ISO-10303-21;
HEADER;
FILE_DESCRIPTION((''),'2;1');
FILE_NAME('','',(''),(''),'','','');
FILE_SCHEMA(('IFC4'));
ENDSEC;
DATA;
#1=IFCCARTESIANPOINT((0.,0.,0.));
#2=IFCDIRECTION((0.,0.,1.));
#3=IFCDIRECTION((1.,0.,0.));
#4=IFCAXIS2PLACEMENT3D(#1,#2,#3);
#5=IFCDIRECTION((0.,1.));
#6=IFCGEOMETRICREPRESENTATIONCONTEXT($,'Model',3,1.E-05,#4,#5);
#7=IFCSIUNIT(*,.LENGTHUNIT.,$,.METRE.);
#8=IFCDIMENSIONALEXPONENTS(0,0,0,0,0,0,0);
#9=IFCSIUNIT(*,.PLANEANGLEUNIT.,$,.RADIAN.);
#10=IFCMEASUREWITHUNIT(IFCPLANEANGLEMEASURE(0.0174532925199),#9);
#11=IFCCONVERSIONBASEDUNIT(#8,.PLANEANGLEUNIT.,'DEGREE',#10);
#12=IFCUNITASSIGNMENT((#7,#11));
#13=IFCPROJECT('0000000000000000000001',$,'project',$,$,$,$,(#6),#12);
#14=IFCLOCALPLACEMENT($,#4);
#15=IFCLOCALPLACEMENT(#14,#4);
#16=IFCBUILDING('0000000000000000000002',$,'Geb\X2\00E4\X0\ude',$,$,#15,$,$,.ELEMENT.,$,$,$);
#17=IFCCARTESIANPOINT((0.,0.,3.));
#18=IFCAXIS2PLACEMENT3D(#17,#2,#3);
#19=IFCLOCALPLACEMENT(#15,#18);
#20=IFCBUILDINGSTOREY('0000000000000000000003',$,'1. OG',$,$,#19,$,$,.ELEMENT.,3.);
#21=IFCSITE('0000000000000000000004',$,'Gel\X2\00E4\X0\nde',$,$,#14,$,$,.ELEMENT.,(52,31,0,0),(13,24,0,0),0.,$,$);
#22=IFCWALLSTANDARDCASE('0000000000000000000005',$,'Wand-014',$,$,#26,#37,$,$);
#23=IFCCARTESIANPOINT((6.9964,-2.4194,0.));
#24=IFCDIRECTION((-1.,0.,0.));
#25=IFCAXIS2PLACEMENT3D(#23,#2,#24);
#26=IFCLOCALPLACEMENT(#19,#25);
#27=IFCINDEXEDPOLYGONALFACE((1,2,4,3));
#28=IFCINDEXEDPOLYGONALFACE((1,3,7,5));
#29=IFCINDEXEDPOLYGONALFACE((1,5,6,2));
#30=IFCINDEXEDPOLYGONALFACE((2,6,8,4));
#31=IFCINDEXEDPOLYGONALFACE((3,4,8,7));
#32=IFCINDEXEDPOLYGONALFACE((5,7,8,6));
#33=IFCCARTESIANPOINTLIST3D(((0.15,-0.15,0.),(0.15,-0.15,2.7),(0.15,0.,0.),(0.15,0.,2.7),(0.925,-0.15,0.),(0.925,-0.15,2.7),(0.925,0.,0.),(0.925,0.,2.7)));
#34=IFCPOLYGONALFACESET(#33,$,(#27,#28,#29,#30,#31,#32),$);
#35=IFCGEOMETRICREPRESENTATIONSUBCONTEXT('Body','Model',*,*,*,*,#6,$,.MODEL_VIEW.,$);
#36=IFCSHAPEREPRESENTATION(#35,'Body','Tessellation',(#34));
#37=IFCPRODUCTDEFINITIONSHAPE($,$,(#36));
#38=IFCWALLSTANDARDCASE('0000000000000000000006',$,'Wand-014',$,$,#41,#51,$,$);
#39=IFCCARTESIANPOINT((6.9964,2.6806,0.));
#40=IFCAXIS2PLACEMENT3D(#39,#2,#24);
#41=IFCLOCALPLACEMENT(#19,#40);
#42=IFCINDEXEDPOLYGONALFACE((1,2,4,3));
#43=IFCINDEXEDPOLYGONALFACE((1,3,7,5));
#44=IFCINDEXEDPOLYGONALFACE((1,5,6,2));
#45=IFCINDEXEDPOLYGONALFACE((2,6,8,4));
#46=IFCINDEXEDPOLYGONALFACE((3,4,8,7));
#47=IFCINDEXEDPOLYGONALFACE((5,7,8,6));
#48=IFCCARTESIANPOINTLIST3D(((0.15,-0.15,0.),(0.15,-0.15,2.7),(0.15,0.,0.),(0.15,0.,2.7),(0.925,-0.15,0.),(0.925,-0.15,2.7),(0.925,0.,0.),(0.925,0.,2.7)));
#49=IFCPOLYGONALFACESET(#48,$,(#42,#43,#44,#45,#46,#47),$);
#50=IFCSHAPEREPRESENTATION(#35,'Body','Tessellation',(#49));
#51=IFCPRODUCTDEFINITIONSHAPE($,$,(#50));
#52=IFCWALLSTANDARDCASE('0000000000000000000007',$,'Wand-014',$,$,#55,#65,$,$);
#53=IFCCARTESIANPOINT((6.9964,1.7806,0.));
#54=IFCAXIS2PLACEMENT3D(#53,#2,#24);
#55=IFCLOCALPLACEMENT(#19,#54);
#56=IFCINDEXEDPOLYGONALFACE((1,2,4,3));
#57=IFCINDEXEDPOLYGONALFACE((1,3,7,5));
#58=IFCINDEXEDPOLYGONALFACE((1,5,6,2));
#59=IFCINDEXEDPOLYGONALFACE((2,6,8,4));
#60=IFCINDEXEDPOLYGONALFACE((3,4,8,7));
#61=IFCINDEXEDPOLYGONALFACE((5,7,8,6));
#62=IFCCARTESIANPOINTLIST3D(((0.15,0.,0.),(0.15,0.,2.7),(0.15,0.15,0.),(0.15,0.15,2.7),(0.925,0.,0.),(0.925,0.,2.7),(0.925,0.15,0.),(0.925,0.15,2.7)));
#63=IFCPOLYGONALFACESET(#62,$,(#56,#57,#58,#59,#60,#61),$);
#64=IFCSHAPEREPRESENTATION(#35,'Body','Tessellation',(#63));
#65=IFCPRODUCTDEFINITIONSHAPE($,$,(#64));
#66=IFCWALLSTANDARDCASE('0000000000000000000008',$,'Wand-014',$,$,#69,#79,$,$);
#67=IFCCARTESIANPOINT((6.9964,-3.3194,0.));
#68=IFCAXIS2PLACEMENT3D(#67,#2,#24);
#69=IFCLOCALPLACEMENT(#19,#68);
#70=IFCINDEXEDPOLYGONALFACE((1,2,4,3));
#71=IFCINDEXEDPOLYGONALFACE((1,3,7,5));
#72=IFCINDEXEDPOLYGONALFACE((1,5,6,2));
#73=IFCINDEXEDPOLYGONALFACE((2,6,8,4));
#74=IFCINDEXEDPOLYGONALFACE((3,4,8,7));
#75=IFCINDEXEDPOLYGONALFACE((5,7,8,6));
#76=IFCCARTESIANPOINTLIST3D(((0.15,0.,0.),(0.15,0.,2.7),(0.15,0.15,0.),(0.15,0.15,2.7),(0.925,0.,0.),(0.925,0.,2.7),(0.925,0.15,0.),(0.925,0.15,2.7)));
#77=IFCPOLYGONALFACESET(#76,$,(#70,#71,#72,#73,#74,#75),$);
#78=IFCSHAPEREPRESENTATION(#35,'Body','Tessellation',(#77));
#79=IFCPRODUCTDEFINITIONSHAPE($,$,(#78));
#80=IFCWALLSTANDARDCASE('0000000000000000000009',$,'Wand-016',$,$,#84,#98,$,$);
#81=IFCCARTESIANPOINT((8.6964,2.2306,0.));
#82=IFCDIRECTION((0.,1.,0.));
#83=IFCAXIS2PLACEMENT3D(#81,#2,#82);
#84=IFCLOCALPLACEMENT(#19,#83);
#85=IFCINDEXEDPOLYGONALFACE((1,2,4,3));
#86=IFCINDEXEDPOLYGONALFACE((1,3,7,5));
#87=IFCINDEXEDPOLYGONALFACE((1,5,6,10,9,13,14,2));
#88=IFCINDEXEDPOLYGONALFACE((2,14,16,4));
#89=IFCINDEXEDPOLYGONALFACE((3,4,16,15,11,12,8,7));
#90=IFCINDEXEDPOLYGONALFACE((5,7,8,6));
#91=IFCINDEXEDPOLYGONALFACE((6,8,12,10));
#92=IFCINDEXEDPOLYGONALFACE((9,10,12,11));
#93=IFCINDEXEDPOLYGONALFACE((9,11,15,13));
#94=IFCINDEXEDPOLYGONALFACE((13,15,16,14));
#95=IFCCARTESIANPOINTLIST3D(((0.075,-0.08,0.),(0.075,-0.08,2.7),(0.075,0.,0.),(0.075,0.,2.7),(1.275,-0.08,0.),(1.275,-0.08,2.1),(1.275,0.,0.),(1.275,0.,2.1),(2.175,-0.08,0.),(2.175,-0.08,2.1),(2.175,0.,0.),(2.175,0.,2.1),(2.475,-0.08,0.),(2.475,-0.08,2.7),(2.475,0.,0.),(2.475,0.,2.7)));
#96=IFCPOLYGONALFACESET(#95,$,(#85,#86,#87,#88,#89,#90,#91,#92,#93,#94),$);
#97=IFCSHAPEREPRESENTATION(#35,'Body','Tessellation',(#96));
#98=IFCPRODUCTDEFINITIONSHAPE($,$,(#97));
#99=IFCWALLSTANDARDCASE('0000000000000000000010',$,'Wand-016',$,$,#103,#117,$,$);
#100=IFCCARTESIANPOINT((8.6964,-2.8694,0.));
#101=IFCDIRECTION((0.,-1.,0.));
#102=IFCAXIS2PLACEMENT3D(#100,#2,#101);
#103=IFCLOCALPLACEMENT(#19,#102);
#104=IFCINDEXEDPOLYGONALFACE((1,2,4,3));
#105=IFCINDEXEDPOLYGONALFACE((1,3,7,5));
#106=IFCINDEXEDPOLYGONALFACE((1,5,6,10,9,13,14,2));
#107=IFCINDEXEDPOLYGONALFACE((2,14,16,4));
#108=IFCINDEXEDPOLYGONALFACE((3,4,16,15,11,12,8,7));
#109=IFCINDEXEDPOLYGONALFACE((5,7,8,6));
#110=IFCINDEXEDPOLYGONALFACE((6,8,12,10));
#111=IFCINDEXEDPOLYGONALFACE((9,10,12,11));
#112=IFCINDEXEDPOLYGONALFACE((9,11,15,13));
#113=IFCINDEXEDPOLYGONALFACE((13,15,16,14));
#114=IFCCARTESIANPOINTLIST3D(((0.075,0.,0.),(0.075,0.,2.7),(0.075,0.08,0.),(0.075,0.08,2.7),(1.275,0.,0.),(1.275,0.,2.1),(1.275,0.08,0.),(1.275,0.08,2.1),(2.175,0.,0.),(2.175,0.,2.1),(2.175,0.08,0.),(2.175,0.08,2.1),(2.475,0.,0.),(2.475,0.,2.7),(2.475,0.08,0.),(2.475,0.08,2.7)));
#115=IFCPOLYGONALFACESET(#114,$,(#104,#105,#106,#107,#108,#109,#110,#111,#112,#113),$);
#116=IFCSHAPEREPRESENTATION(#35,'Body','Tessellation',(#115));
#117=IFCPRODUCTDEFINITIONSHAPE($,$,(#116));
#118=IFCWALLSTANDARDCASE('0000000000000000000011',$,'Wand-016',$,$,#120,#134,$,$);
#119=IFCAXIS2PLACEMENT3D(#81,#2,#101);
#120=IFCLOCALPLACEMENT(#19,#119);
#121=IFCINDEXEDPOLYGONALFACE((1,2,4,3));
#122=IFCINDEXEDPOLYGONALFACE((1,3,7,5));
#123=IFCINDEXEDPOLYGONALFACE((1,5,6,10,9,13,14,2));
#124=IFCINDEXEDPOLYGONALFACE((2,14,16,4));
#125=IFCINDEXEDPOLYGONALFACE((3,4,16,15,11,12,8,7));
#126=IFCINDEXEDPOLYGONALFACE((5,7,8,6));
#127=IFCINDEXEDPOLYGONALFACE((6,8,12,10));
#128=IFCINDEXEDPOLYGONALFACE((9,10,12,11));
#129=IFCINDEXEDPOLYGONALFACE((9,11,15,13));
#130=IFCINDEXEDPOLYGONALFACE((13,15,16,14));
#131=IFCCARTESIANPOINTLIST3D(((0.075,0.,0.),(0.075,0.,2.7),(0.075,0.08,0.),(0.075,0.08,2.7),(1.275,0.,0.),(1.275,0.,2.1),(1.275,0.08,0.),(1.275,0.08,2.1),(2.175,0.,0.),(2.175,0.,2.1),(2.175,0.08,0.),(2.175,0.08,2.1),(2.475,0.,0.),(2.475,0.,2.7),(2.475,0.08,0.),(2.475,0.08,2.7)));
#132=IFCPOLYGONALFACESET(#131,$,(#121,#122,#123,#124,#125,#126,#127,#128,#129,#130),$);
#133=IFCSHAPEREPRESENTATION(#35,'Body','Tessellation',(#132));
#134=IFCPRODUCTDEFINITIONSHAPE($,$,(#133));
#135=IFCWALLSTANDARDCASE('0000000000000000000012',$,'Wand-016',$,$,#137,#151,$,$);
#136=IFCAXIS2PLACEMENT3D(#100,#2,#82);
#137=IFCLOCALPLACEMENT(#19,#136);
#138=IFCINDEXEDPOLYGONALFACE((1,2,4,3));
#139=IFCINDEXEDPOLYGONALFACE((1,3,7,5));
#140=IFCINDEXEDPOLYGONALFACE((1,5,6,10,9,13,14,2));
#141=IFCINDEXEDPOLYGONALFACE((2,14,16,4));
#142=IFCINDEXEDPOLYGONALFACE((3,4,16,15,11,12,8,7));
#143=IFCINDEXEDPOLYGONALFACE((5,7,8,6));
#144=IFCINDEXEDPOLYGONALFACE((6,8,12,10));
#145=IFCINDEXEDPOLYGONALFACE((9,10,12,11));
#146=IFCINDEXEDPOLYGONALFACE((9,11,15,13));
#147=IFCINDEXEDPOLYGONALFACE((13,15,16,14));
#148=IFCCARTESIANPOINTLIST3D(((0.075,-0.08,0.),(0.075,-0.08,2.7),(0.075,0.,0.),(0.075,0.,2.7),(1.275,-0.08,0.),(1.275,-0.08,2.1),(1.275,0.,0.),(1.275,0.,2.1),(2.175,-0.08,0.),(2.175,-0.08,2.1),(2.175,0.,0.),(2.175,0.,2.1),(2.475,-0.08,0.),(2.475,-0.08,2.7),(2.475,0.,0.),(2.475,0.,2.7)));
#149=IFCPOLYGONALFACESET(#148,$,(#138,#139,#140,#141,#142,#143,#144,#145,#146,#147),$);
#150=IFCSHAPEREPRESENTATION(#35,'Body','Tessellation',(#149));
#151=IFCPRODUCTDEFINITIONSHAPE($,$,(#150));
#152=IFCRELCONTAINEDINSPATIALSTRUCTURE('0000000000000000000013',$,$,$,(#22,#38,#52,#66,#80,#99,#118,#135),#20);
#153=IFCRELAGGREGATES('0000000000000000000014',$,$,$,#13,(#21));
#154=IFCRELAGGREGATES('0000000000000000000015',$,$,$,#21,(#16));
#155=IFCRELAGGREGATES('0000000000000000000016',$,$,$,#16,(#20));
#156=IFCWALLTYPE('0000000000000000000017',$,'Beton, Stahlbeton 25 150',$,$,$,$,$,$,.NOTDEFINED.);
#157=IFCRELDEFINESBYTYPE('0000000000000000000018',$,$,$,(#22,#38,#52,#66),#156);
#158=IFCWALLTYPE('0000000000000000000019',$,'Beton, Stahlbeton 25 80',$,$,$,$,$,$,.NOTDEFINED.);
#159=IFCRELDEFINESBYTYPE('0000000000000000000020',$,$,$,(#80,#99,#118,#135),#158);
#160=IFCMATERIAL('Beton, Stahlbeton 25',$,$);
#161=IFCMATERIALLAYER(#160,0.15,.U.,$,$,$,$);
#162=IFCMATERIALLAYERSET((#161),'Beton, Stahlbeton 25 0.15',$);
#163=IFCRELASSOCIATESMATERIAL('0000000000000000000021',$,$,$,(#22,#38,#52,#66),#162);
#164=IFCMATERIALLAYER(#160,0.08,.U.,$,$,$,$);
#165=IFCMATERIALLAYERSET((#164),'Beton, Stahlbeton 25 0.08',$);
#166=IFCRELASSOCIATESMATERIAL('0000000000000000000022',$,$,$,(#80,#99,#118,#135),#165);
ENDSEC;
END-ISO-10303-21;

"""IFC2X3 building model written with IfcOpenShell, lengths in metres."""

from ifc_helpers import new_model, entity, si_unit, converted_unit, direction, frame, origin_with_axes, origin_2d_with_axis, place, context, subcontext, project, spatial, polyline, rectangle, outline, extrude, material, layer, layer_set, layer_usage, type_object, element, save


model = new_model("IFC2X3")

# Units and contexts
model_context = context("Model", 3, precision=1e-05, world=origin_with_axes(), true_north=direction((0.0, 1.0)))
body_context = subcontext(model_context, "Body", "Model", "MODEL_VIEW")
ifc_project = project(units=[si_unit("LENGTHUNIT", "METRE"), converted_unit("PLANEANGLEUNIT", "DEGREE", entity("IfcPlaneAngleMeasure", 0.0174532925199), si_unit("PLANEANGLEUNIT", "RADIAN"), dimensions=[0, 0, 0, 0, 0, 0, 0])], contexts=[model_context])

# Site, building, storey
site_placement = place(None, origin_with_axes())
site = spatial("IfcSite", under=ifc_project, at=site_placement, Name="Gelände", CompositionType="ELEMENT", RefLatitude=(52, 31, 0, 0), RefLongitude=(13, 24, 0, 0), RefElevation=0.0)
building_placement = place(site_placement, origin_with_axes())
building = spatial("IfcBuilding", under=site, at=building_placement, Name="Gebäude", CompositionType="ELEMENT")
storey_placement = place(building_placement, frame((0.0, 0.0, 3.0), z_axis=(0.0, 0.0, 1.0), x_axis=(1.0, 0.0, 0.0)))
storey = spatial("IfcBuildingStorey", under=building, at=storey_placement, Name="1. OG", CompositionType="ELEMENT", Elevation=3.0)

# Wall
ifc_material = material(Name="Beton, Stahlbeton 25")
ifc_layer_1 = layer(ifc_material, 0.15, ventilated="UNKNOWN")
ifc_layer_set_1 = layer_set([ifc_layer_1], Name="Beton, Stahlbeton 25 0.15")
ifc_layer_usage_1 = layer_usage(ifc_layer_set_1, "AXIS2", "NEGATIVE", 0.0)
wall_type_1 = type_object("IfcWallType", Name="Beton, Stahlbeton 25 150", PredefinedType="NOTDEFINED")
wall_1_placement = place(storey_placement, frame((6.9964, -2.4194, 0.0), z_axis=(0.0, 0.0, 1.0), x_axis=(-1.0, 0.0, 0.0)))
element("IfcWallStandardCase", 1, at=wall_1_placement, inside=storey, type_object=wall_type_1, material=ifc_layer_usage_1, Name="Wand-014", context=body_context, shape_type="SweptSolid", body=[
    extrude(outline(polyline([(0.15, -0.15), (0.925, -0.15), (0.925, 0.0), (0.15, 0.0), (0.15, -0.15)])), origin_with_axes(), (0.0, 0.0, 1.0), 2.7),
])

# Walls
ifc_layer_usage_2 = layer_usage(ifc_layer_set_1, "AXIS2", "NEGATIVE", 0.0)
wall_2_placement = place(storey_placement, frame((6.9964, 2.6806, 0.0), z_axis=(0.0, 0.0, 1.0), x_axis=(-1.0, 0.0, 0.0)))
element("IfcWallStandardCase", 2, at=wall_2_placement, inside=storey, type_object=wall_type_1, material=ifc_layer_usage_2, Name="Wand-014", context=body_context, shape_type="SweptSolid", body=[
    extrude(outline(polyline([(0.15, -0.15), (0.925, -0.15), (0.925, 0.0), (0.15, 0.0), (0.15, -0.15)])), origin_with_axes(), (0.0, 0.0, 1.0), 2.7),
])
ifc_layer_usage_3 = layer_usage(ifc_layer_set_1, "AXIS2", "POSITIVE", 0.0)
wall_3_placement = place(storey_placement, frame((6.9964, 1.7806, 0.0), z_axis=(0.0, 0.0, 1.0), x_axis=(-1.0, 0.0, 0.0)))
element("IfcWallStandardCase", 3, at=wall_3_placement, inside=storey, type_object=wall_type_1, material=ifc_layer_usage_3, Name="Wand-014", context=body_context, shape_type="SweptSolid", body=[
    extrude(outline(polyline([(0.15, 0.0), (0.925, 0.0), (0.925, 0.15), (0.15, 0.15), (0.15, 0.0)])), origin_with_axes(), (0.0, 0.0, 1.0), 2.7),
])

# Wall
ifc_layer_usage_4 = layer_usage(ifc_layer_set_1, "AXIS2", "POSITIVE", 0.0)
wall_4_placement = place(storey_placement, frame((6.9964, -3.3194, 0.0), z_axis=(0.0, 0.0, 1.0), x_axis=(-1.0, 0.0, 0.0)))
element("IfcWallStandardCase", 4, at=wall_4_placement, inside=storey, type_object=wall_type_1, material=ifc_layer_usage_4, Name="Wand-014", context=body_context, shape_type="SweptSolid", body=[
    extrude(outline(polyline([(0.15, 0.0), (0.925, 0.0), (0.925, 0.15), (0.15, 0.15), (0.15, 0.0)])), origin_with_axes(), (0.0, 0.0, 1.0), 2.7),
])

# Walls, openings
ifc_layer_2 = layer(ifc_material, 0.08, ventilated="UNKNOWN")
ifc_layer_set_2 = layer_set([ifc_layer_2], Name="Beton, Stahlbeton 25 0.08")
wall_type_2 = type_object("IfcWallType", Name="Beton, Stahlbeton 25 80", PredefinedType="NOTDEFINED")
ifc_layer_usage_5 = layer_usage(ifc_layer_set_2, "AXIS2", "NEGATIVE", 0.0)
wall_5_placement = place(storey_placement, frame((8.6964, 2.2306, 0.0), z_axis=(0.0, 0.0, 1.0), x_axis=(0.0, 1.0, 0.0)))
wall_5 = element("IfcWallStandardCase", 5, at=wall_5_placement, inside=storey, type_object=wall_type_2, material=ifc_layer_usage_5, Name="Wand-016", context=body_context, shape_type="SweptSolid", body=[
    extrude(outline(polyline([(0.075, -0.08), (2.475, -0.08), (2.475, 0.0), (0.075, 0.0), (0.075, -0.08)])), origin_with_axes(), (0.0, 0.0, 1.0), 2.7),
])
opening_1_placement = place(wall_5_placement, frame((1.725, 0.0, 0.0), z_axis=(0.0, 0.0, 1.0), x_axis=(1.0, 0.0, 0.0)))
element("IfcOpeningElement", 6, at=opening_1_placement, cuts=wall_5, context=body_context, shape_type="SweptSolid", body=[
    extrude(rectangle(XDim=0.9, YDim=2.1, at=origin_2d_with_axis()), frame((0.0, -0.16, 1.05), z_axis=(0.0, 1.0, 0.0), x_axis=(1.0, 0.0, 0.0)), (0.0, 0.0, 1.0), 0.08),
    extrude(rectangle(XDim=0.9, YDim=2.1, at=origin_2d_with_axis()), frame((0.0, 0.0, 1.05), z_axis=(0.0, -1.0, 0.0), x_axis=(1.0, 0.0, 0.0)), (0.0, 0.0, 1.0), 0.08),
])
ifc_layer_usage_6 = layer_usage(ifc_layer_set_2, "AXIS2", "POSITIVE", 0.0)
wall_6_placement = place(storey_placement, frame((8.6964, -2.8694, 0.0), z_axis=(0.0, 0.0, 1.0), x_axis=(0.0, -1.0, 0.0)))
wall_6 = element("IfcWallStandardCase", 7, at=wall_6_placement, inside=storey, type_object=wall_type_2, material=ifc_layer_usage_6, Name="Wand-016", context=body_context, shape_type="SweptSolid", body=[
    extrude(outline(polyline([(0.075, 0.0), (2.475, 0.0), (2.475, 0.08), (0.075, 0.08), (0.075, 0.0)])), origin_with_axes(), (0.0, 0.0, 1.0), 2.7),
])
opening_2_placement = place(wall_6_placement, frame((1.725, 0.0, 0.0), z_axis=(0.0, 0.0, 1.0), x_axis=(1.0, 0.0, 0.0)))
element("IfcOpeningElement", 8, at=opening_2_placement, cuts=wall_6, context=body_context, shape_type="SweptSolid", body=[
    extrude(rectangle(XDim=0.9, YDim=2.1, at=origin_2d_with_axis()), frame((0.0, 0.16, 1.05), z_axis=(0.0, -1.0, 0.0), x_axis=(1.0, 0.0, 0.0)), (0.0, 0.0, 1.0), 0.08),
    extrude(rectangle(XDim=0.9, YDim=2.1, at=origin_2d_with_axis()), frame((0.0, 0.0, 1.05), z_axis=(0.0, 1.0, 0.0), x_axis=(1.0, 0.0, 0.0)), (0.0, 0.0, 1.0), 0.08),
])
ifc_layer_usage_7 = layer_usage(ifc_layer_set_2, "AXIS2", "POSITIVE", 0.0)
wall_7_placement = place(storey_placement, frame((8.6964, 2.2306, 0.0), z_axis=(0.0, 0.0, 1.0), x_axis=(0.0, -1.0, 0.0)))
wall_7 = element("IfcWallStandardCase", 9, at=wall_7_placement, inside=storey, type_object=wall_type_2, material=ifc_layer_usage_7, Name="Wand-016", context=body_context, shape_type="SweptSolid", body=[
    extrude(outline(polyline([(0.075, 0.0), (2.475, 0.0), (2.475, 0.08), (0.075, 0.08), (0.075, 0.0)])), origin_with_axes(), (0.0, 0.0, 1.0), 2.7),
])
opening_3_placement = place(wall_7_placement, frame((1.725, 0.0, 0.0), z_axis=(0.0, 0.0, 1.0), x_axis=(1.0, 0.0, 0.0)))
element("IfcOpeningElement", 10, at=opening_3_placement, cuts=wall_7, context=body_context, shape_type="SweptSolid", body=[
    extrude(rectangle(XDim=0.9, YDim=2.1, at=origin_2d_with_axis()), frame((0.0, 0.16, 1.05), z_axis=(0.0, -1.0, 0.0), x_axis=(1.0, 0.0, 0.0)), (0.0, 0.0, 1.0), 0.08),
    extrude(rectangle(XDim=0.9, YDim=2.1, at=origin_2d_with_axis()), frame((0.0, 0.0, 1.05), z_axis=(0.0, 1.0, 0.0), x_axis=(1.0, 0.0, 0.0)), (0.0, 0.0, 1.0), 0.08),
])
ifc_layer_usage_8 = layer_usage(ifc_layer_set_2, "AXIS2", "NEGATIVE", 0.0)
wall_8_placement = place(storey_placement, frame((8.6964, -2.8694, 0.0), z_axis=(0.0, 0.0, 1.0), x_axis=(0.0, 1.0, 0.0)))
wall_8 = element("IfcWallStandardCase", 11, at=wall_8_placement, inside=storey, type_object=wall_type_2, material=ifc_layer_usage_8, Name="Wand-016", context=body_context, shape_type="SweptSolid", body=[
    extrude(outline(polyline([(0.075, -0.08), (2.475, -0.08), (2.475, 0.0), (0.075, 0.0), (0.075, -0.08)])), origin_with_axes(), (0.0, 0.0, 1.0), 2.7),
])
opening_4_placement = place(wall_8_placement, frame((1.725, 0.0, 0.0), z_axis=(0.0, 0.0, 1.0), x_axis=(1.0, 0.0, 0.0)))
element("IfcOpeningElement", 12, at=opening_4_placement, cuts=wall_8, context=body_context, shape_type="SweptSolid", body=[
    extrude(rectangle(XDim=0.9, YDim=2.1, at=origin_2d_with_axis()), frame((0.0, -0.16, 1.05), z_axis=(0.0, 1.0, 0.0), x_axis=(1.0, 0.0, 0.0)), (0.0, 0.0, 1.0), 0.08),
    extrude(rectangle(XDim=0.9, YDim=2.1, at=origin_2d_with_axis()), frame((0.0, 0.0, 1.05), z_axis=(0.0, -1.0, 0.0), x_axis=(1.0, 0.0, 0.0)), (0.0, 0.0, 1.0), 0.08),
])

save(model, "model.ifc")
